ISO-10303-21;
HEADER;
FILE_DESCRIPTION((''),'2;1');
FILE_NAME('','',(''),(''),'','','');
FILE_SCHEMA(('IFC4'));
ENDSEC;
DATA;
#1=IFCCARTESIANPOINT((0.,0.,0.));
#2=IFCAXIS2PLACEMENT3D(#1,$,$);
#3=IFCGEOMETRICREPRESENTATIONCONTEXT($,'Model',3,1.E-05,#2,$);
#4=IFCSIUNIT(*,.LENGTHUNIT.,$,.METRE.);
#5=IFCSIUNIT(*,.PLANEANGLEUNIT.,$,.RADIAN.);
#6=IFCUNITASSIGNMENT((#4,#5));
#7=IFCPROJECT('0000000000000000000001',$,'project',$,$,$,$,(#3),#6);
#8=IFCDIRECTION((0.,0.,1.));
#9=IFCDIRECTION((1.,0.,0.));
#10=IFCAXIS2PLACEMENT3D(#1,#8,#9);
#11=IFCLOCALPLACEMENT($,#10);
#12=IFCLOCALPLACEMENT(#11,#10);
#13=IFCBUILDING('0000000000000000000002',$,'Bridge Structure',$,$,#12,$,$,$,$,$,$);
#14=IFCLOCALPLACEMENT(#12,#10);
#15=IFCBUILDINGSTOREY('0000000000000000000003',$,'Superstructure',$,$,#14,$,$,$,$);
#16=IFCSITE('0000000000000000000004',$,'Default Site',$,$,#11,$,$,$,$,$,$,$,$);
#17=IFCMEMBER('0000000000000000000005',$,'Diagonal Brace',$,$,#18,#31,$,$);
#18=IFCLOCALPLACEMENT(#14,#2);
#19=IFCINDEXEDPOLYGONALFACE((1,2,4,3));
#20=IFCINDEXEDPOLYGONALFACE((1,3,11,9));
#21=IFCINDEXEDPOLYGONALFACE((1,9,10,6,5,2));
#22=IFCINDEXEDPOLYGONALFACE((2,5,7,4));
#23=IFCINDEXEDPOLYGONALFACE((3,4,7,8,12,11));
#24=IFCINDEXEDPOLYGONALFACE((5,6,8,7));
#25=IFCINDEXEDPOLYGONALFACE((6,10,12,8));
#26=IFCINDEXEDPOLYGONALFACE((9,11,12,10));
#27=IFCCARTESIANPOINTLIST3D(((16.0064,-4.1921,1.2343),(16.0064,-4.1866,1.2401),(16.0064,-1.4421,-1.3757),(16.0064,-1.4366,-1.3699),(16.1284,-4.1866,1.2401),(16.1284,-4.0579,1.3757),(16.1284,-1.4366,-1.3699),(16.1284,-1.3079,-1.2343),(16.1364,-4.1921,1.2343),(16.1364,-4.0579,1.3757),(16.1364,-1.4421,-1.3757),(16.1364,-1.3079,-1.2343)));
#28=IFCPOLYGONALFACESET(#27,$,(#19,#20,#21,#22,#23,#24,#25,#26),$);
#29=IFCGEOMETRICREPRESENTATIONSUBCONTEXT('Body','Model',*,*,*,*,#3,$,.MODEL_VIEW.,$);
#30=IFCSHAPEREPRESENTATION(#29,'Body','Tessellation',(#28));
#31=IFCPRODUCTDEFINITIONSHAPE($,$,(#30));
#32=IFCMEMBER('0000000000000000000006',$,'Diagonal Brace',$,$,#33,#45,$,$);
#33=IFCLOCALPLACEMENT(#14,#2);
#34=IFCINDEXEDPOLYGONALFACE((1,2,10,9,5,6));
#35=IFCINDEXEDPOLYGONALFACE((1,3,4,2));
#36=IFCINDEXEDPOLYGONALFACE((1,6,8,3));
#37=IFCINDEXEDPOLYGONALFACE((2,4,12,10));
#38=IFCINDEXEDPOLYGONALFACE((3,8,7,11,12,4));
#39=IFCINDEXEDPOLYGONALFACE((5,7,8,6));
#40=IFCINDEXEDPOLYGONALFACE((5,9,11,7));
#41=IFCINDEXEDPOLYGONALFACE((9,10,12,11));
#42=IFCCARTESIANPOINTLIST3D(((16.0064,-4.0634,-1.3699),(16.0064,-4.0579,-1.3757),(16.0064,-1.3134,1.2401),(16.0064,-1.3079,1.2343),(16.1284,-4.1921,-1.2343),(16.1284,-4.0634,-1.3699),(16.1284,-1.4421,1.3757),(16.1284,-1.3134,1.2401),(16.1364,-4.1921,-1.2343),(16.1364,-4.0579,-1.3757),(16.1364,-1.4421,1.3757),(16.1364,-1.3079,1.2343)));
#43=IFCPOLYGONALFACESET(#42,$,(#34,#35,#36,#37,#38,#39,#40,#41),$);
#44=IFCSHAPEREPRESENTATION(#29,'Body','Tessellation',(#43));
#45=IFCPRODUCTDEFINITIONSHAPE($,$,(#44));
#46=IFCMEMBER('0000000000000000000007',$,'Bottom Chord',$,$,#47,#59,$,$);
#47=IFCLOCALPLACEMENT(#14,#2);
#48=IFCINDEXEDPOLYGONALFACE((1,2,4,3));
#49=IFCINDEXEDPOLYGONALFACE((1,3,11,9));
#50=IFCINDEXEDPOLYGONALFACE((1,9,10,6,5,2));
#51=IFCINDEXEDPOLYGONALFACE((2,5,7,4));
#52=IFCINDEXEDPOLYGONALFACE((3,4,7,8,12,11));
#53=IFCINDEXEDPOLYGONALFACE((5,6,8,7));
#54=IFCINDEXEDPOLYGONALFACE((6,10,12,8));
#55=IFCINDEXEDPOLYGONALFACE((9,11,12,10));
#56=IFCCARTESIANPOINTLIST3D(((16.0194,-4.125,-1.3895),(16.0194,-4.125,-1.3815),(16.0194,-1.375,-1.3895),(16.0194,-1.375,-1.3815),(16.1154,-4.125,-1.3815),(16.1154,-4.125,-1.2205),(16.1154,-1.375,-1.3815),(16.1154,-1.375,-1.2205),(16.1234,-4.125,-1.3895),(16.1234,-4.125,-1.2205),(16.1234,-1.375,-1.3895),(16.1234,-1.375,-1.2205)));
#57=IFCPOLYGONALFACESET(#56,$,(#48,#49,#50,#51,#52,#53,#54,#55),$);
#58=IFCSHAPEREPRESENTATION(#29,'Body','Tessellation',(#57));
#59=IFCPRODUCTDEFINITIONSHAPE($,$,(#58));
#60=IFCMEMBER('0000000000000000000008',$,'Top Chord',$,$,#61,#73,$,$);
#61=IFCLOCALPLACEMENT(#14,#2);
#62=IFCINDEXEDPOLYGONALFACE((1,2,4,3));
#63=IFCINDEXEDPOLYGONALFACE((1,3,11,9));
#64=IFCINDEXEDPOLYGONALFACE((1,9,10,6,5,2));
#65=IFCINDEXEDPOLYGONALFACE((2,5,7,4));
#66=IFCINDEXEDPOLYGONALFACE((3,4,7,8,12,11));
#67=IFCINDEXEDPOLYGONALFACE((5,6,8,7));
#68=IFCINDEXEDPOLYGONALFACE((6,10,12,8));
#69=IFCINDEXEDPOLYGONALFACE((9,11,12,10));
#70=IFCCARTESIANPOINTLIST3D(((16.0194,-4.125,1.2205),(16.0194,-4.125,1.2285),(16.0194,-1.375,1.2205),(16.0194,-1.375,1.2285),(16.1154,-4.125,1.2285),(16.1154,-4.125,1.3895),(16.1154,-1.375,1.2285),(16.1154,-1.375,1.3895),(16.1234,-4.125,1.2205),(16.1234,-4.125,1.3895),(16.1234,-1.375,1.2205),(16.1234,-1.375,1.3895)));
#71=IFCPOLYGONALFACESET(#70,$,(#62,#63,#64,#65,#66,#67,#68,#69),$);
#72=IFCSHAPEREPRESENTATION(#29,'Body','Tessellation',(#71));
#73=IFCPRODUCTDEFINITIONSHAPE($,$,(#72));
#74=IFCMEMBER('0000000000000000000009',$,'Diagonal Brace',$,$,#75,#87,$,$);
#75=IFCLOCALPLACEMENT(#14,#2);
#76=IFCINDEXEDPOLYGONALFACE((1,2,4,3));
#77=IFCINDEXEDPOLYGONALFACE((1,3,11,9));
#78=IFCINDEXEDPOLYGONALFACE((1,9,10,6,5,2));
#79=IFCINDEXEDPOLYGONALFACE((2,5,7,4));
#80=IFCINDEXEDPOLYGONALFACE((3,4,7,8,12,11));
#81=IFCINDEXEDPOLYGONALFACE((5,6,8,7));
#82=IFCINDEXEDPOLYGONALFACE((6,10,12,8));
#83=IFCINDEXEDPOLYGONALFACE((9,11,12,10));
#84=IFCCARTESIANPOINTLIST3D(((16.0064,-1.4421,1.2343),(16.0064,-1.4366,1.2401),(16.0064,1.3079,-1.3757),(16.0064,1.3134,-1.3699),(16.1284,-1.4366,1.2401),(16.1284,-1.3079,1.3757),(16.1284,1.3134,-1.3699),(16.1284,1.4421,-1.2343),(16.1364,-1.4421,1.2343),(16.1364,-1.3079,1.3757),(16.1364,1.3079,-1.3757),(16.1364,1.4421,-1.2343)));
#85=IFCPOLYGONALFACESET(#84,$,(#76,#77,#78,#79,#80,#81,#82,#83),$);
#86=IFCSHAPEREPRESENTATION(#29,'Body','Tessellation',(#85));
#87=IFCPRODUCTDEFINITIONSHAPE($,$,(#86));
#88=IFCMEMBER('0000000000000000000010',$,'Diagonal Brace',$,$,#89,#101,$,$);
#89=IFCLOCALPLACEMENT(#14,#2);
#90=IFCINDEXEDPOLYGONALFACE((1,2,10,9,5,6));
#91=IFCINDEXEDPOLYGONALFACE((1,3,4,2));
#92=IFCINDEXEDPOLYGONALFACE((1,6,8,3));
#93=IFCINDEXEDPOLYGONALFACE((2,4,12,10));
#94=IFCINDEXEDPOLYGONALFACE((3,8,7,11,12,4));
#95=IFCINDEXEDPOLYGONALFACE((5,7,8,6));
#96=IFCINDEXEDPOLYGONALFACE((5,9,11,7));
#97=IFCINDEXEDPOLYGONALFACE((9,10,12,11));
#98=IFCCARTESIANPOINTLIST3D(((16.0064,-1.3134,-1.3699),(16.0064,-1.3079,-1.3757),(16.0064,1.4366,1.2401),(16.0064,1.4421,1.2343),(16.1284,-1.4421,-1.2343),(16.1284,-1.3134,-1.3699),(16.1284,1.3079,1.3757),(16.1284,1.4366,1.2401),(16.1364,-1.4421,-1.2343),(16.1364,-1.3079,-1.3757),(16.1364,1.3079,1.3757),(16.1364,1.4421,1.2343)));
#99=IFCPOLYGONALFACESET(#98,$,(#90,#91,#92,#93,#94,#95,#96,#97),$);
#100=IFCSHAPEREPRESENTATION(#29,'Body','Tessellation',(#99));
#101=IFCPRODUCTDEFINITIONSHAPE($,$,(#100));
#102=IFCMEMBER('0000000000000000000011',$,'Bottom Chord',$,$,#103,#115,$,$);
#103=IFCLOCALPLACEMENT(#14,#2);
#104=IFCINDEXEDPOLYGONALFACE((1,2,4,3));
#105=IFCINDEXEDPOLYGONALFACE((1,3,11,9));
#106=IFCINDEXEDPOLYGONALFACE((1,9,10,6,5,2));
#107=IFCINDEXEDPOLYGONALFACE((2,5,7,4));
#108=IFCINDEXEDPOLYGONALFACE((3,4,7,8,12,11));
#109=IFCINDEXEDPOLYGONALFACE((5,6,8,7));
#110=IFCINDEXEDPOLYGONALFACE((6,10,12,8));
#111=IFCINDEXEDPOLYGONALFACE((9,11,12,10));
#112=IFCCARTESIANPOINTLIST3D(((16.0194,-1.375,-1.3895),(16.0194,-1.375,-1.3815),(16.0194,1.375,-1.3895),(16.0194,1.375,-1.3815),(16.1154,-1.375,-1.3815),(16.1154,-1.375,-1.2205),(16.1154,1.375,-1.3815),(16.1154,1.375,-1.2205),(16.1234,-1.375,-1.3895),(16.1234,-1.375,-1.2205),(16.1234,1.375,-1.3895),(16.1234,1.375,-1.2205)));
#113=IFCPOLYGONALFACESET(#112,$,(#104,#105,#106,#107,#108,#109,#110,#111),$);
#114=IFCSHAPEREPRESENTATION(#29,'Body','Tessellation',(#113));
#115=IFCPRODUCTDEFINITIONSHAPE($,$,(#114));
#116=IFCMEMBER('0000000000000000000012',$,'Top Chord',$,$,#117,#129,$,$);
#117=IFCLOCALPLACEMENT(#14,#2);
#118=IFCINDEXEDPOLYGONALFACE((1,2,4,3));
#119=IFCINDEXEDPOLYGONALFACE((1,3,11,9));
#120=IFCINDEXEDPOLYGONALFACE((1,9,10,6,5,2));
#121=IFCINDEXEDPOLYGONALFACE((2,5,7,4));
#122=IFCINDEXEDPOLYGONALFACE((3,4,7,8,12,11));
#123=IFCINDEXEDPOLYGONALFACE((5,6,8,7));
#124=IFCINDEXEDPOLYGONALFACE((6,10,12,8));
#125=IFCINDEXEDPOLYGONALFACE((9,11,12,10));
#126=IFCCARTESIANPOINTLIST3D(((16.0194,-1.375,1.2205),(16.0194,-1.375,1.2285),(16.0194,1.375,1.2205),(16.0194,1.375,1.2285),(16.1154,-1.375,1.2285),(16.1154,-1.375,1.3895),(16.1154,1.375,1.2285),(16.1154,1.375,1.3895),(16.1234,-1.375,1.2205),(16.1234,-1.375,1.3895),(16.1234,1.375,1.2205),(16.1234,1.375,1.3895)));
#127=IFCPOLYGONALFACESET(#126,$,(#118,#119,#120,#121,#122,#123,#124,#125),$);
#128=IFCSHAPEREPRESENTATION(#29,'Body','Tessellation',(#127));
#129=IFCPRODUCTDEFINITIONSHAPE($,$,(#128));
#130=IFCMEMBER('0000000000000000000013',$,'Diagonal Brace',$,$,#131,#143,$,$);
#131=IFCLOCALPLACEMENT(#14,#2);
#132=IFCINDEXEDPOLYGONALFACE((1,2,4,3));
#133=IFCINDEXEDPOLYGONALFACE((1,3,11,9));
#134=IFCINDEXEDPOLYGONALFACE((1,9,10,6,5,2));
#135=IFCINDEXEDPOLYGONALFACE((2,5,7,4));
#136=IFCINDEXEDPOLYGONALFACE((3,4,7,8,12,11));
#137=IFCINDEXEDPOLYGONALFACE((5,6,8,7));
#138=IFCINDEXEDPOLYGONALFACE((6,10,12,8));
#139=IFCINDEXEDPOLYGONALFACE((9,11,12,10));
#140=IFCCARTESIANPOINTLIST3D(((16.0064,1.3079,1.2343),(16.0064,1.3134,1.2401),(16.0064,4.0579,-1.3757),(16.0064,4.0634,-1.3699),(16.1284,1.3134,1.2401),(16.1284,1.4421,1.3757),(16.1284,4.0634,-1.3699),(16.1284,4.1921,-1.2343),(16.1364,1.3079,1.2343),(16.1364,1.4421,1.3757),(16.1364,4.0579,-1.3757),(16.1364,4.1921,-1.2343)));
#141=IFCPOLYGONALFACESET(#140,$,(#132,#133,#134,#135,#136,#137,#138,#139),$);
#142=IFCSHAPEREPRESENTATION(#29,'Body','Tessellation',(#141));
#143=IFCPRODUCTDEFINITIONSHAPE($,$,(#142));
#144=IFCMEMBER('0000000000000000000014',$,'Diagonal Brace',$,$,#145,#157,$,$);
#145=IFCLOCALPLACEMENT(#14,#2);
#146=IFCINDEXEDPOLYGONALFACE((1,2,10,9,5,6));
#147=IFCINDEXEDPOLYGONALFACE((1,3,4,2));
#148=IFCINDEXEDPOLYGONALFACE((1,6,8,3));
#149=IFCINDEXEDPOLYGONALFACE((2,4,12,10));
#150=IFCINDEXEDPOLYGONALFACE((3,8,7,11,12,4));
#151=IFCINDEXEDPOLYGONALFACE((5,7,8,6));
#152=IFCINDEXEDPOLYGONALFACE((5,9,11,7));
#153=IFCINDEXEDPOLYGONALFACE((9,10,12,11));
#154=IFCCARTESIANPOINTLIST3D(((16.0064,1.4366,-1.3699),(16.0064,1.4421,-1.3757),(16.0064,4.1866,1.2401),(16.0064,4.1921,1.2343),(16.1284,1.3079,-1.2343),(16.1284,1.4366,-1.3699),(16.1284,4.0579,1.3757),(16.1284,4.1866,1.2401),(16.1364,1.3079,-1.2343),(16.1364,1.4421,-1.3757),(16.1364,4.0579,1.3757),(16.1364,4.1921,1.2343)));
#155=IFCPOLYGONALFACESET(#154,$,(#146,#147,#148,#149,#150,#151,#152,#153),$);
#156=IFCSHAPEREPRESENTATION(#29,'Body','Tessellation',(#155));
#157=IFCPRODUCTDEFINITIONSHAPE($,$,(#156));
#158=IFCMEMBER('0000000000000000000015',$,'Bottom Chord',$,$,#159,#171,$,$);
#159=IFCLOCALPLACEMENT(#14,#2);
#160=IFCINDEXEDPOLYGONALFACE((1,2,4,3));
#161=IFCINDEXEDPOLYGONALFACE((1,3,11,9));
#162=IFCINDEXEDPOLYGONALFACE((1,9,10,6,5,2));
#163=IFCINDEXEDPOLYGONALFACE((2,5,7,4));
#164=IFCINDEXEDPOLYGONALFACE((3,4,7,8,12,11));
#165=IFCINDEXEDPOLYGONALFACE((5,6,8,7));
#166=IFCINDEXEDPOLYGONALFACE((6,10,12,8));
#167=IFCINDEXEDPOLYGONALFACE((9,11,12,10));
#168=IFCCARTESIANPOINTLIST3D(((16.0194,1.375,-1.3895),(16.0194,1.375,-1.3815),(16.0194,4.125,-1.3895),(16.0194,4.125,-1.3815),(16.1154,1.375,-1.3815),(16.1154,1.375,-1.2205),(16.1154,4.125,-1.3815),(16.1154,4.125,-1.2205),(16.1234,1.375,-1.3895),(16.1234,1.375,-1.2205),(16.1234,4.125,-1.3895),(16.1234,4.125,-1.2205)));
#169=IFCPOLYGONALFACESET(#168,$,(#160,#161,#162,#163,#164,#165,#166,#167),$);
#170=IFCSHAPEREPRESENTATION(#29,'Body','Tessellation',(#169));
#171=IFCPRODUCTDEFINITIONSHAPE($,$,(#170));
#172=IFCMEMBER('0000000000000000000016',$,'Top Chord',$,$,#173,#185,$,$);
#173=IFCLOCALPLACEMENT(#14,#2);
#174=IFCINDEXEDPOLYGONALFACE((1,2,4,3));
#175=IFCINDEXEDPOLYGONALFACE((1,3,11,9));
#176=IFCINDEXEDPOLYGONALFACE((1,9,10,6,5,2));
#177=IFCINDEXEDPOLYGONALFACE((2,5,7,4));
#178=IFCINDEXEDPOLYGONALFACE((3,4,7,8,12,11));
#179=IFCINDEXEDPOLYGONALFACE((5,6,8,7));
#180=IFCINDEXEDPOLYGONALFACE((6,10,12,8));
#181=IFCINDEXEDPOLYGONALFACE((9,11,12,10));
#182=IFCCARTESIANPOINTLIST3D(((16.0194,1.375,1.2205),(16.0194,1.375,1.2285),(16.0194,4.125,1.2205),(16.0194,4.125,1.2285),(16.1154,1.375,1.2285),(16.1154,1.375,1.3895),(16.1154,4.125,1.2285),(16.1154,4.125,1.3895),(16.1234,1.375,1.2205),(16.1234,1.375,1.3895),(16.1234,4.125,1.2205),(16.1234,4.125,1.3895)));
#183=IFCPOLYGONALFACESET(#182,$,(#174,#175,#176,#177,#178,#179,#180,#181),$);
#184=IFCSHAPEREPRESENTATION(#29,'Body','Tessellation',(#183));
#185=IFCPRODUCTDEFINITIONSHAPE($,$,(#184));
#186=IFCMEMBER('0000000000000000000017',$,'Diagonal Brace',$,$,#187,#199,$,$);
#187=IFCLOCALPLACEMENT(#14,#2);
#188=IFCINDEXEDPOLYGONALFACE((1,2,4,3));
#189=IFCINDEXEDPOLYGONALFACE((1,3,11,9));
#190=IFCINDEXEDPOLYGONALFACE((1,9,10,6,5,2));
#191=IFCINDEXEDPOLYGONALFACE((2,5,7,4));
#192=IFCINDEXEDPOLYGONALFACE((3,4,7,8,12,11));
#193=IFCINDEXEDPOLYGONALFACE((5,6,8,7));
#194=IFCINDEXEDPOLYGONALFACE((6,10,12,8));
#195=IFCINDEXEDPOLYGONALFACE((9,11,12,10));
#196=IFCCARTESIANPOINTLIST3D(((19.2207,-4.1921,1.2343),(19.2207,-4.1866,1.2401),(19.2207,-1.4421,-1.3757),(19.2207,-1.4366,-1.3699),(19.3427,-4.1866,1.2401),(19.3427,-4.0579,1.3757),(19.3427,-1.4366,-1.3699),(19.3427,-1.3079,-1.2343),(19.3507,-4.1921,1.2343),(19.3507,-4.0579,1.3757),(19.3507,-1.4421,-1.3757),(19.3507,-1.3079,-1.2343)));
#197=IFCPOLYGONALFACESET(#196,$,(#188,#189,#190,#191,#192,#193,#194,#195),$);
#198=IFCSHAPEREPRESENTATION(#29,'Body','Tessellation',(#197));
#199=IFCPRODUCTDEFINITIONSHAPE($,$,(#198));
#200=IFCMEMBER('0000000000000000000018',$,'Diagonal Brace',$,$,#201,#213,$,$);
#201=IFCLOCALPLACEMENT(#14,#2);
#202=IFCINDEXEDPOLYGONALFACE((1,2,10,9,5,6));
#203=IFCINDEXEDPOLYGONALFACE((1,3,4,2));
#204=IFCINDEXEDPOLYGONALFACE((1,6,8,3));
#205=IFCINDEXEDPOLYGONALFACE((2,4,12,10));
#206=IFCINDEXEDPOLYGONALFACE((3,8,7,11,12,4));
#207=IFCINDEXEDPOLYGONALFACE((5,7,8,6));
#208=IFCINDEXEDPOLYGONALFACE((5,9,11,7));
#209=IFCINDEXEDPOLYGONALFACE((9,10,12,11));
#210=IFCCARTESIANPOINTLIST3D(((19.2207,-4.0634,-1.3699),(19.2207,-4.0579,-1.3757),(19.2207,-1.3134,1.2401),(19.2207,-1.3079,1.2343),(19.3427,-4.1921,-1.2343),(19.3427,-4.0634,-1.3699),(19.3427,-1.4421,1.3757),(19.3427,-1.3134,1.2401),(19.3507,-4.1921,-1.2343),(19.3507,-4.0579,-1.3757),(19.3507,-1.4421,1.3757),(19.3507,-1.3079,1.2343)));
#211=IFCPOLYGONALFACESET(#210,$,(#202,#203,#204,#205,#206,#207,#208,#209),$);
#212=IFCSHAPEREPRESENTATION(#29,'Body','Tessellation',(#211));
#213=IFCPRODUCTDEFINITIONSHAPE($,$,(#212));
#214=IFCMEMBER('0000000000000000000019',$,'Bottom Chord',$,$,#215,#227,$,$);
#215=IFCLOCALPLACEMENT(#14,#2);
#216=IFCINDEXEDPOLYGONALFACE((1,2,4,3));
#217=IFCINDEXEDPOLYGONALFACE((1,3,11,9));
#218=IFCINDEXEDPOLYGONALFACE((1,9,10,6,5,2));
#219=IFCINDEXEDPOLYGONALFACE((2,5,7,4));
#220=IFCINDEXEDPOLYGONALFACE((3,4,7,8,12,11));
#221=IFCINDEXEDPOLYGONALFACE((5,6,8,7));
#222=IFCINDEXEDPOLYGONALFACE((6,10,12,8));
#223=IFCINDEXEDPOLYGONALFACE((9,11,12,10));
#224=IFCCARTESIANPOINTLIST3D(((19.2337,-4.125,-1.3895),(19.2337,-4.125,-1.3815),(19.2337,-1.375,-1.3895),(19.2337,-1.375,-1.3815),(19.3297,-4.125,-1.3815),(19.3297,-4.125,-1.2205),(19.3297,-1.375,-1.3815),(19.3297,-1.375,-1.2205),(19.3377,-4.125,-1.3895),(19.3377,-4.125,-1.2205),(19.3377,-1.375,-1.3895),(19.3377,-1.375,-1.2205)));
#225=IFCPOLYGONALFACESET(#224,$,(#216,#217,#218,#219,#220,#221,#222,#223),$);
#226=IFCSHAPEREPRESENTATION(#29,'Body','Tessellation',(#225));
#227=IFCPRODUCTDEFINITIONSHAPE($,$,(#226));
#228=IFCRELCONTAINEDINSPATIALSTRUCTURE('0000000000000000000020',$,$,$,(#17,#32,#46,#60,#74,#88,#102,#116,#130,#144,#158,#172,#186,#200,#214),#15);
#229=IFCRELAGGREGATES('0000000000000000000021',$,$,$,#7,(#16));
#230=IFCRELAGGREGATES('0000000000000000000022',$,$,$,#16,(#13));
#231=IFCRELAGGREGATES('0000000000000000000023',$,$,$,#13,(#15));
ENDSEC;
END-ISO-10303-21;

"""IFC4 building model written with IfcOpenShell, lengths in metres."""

from ifc_helpers import new_model, si_unit, frame, origin, origin_with_axes, origin_2d_with_axis, place, context, subcontext, project, spatial, l_section, extrude, element, save


model = new_model("IFC4")

# Units and contexts
model_context = context("Model", 3, precision=1e-05, world=origin())
body_context = subcontext(model_context, "Body", "Model", "MODEL_VIEW")
ifc_project = project(units=[si_unit("LENGTHUNIT", "METRE"), si_unit("PLANEANGLEUNIT", "RADIAN")], contexts=[model_context])

# Site, building, storey
site_placement = place(None, origin_with_axes())
site = spatial("IfcSite", under=ifc_project, at=site_placement, Name="Default Site")
building_placement = place(site_placement, origin_with_axes())
building = spatial("IfcBuilding", under=site, at=building_placement, Name="Bridge Structure")
storey_placement = place(building_placement, origin_with_axes())
storey = spatial("IfcBuildingStorey", under=building, at=storey_placement, Name="Superstructure")

# Members
for number, where, z_axis, x_axis, name in (
    (1, (16.0714, -4.125, 1.305), (0.0, 0.725329, -0.688403), (-1.0, 0.0, 0.0), "Diagonal Brace"),
    (2, (16.0714, -4.125, -1.305), (0.0, 0.725329, 0.688403), (-1.0, 0.0, 0.0), "Diagonal Brace"),
):
    element("IfcMember", number, at=place(storey_placement, frame(where, z_axis=z_axis, x_axis=x_axis)), inside=storey, Name=name, context=body_context, shape_type="SweptSolid", body=[
        extrude(l_section(Depth=0.195, Width=0.13, Thickness=0.008, at=origin_2d_with_axis()), origin_with_axes(), (0.0, 0.0, 1.0), 3.7914),
    ])
for number, where, z_axis, x_axis, name in (
    (3, (16.0714, -4.125, -1.305), (0.0, 1.0, 0.0), (-1.0, 0.0, 0.0), "Bottom Chord"),
    (4, (16.0714, -4.125, 1.305), (0.0, 1.0, 0.0), (-1.0, 0.0, 0.0), "Top Chord"),
):
    element("IfcMember", number, at=place(storey_placement, frame(where, z_axis=z_axis, x_axis=x_axis)), inside=storey, Name=name, context=body_context, shape_type="SweptSolid", body=[
        extrude(l_section(Depth=0.169, Width=0.104, Thickness=0.008, at=origin_2d_with_axis()), origin_with_axes(), (0.0, 0.0, 1.0), 2.75),
    ])
for number, where, z_axis, x_axis, name in (
    (5, (16.0714, -1.375, 1.305), (0.0, 0.725329, -0.688403), (-1.0, 0.0, 0.0), "Diagonal Brace"),
    (6, (16.0714, -1.375, -1.305), (0.0, 0.725329, 0.688403), (-1.0, 0.0, 0.0), "Diagonal Brace"),
):
    element("IfcMember", number, at=place(storey_placement, frame(where, z_axis=z_axis, x_axis=x_axis)), inside=storey, Name=name, context=body_context, shape_type="SweptSolid", body=[
        extrude(l_section(Depth=0.195, Width=0.13, Thickness=0.008, at=origin_2d_with_axis()), origin_with_axes(), (0.0, 0.0, 1.0), 3.7914),
    ])
for number, where, z_axis, x_axis, name in (
    (7, (16.0714, -1.375, -1.305), (0.0, 1.0, 0.0), (-1.0, 0.0, 0.0), "Bottom Chord"),
    (8, (16.0714, -1.375, 1.305), (0.0, 1.0, 0.0), (-1.0, 0.0, 0.0), "Top Chord"),
):
    element("IfcMember", number, at=place(storey_placement, frame(where, z_axis=z_axis, x_axis=x_axis)), inside=storey, Name=name, context=body_context, shape_type="SweptSolid", body=[
        extrude(l_section(Depth=0.169, Width=0.104, Thickness=0.008, at=origin_2d_with_axis()), origin_with_axes(), (0.0, 0.0, 1.0), 2.75),
    ])
for number, where, z_axis, x_axis, name in (
    (9, (16.0714, 1.375, 1.305), (0.0, 0.725329, -0.688403), (-1.0, 0.0, 0.0), "Diagonal Brace"),
    (10, (16.0714, 1.375, -1.305), (0.0, 0.725329, 0.688403), (-1.0, 0.0, 0.0), "Diagonal Brace"),
):
    element("IfcMember", number, at=place(storey_placement, frame(where, z_axis=z_axis, x_axis=x_axis)), inside=storey, Name=name, context=body_context, shape_type="SweptSolid", body=[
        extrude(l_section(Depth=0.195, Width=0.13, Thickness=0.008, at=origin_2d_with_axis()), origin_with_axes(), (0.0, 0.0, 1.0), 3.7914),
    ])
for number, where, z_axis, x_axis, name in (
    (11, (16.0714, 1.375, -1.305), (0.0, 1.0, 0.0), (-1.0, 0.0, 0.0), "Bottom Chord"),
    (12, (16.0714, 1.375, 1.305), (0.0, 1.0, 0.0), (-1.0, 0.0, 0.0), "Top Chord"),
):
    element("IfcMember", number, at=place(storey_placement, frame(where, z_axis=z_axis, x_axis=x_axis)), inside=storey, Name=name, context=body_context, shape_type="SweptSolid", body=[
        extrude(l_section(Depth=0.169, Width=0.104, Thickness=0.008, at=origin_2d_with_axis()), origin_with_axes(), (0.0, 0.0, 1.0), 2.75),
    ])
for number, where, z_axis, x_axis, name in (
    (13, (19.2857, -4.125, 1.305), (0.0, 0.725329, -0.688403), (-1.0, 0.0, 0.0), "Diagonal Brace"),
    (14, (19.2857, -4.125, -1.305), (0.0, 0.725329, 0.688403), (-1.0, 0.0, 0.0), "Diagonal Brace"),
):
    element("IfcMember", number, at=place(storey_placement, frame(where, z_axis=z_axis, x_axis=x_axis)), inside=storey, Name=name, context=body_context, shape_type="SweptSolid", body=[
        extrude(l_section(Depth=0.195, Width=0.13, Thickness=0.008, at=origin_2d_with_axis()), origin_with_axes(), (0.0, 0.0, 1.0), 3.7914),
    ])
for number, where, z_axis, x_axis, name in (
    (15, (19.2857, -4.125, -1.305), (0.0, 1.0, 0.0), (-1.0, 0.0, 0.0), "Bottom Chord"),
):
    element("IfcMember", number, at=place(storey_placement, frame(where, z_axis=z_axis, x_axis=x_axis)), inside=storey, Name=name, context=body_context, shape_type="SweptSolid", body=[
        extrude(l_section(Depth=0.169, Width=0.104, Thickness=0.008, at=origin_2d_with_axis()), origin_with_axes(), (0.0, 0.0, 1.0), 2.75),
    ])

save(model, "model.ifc")
